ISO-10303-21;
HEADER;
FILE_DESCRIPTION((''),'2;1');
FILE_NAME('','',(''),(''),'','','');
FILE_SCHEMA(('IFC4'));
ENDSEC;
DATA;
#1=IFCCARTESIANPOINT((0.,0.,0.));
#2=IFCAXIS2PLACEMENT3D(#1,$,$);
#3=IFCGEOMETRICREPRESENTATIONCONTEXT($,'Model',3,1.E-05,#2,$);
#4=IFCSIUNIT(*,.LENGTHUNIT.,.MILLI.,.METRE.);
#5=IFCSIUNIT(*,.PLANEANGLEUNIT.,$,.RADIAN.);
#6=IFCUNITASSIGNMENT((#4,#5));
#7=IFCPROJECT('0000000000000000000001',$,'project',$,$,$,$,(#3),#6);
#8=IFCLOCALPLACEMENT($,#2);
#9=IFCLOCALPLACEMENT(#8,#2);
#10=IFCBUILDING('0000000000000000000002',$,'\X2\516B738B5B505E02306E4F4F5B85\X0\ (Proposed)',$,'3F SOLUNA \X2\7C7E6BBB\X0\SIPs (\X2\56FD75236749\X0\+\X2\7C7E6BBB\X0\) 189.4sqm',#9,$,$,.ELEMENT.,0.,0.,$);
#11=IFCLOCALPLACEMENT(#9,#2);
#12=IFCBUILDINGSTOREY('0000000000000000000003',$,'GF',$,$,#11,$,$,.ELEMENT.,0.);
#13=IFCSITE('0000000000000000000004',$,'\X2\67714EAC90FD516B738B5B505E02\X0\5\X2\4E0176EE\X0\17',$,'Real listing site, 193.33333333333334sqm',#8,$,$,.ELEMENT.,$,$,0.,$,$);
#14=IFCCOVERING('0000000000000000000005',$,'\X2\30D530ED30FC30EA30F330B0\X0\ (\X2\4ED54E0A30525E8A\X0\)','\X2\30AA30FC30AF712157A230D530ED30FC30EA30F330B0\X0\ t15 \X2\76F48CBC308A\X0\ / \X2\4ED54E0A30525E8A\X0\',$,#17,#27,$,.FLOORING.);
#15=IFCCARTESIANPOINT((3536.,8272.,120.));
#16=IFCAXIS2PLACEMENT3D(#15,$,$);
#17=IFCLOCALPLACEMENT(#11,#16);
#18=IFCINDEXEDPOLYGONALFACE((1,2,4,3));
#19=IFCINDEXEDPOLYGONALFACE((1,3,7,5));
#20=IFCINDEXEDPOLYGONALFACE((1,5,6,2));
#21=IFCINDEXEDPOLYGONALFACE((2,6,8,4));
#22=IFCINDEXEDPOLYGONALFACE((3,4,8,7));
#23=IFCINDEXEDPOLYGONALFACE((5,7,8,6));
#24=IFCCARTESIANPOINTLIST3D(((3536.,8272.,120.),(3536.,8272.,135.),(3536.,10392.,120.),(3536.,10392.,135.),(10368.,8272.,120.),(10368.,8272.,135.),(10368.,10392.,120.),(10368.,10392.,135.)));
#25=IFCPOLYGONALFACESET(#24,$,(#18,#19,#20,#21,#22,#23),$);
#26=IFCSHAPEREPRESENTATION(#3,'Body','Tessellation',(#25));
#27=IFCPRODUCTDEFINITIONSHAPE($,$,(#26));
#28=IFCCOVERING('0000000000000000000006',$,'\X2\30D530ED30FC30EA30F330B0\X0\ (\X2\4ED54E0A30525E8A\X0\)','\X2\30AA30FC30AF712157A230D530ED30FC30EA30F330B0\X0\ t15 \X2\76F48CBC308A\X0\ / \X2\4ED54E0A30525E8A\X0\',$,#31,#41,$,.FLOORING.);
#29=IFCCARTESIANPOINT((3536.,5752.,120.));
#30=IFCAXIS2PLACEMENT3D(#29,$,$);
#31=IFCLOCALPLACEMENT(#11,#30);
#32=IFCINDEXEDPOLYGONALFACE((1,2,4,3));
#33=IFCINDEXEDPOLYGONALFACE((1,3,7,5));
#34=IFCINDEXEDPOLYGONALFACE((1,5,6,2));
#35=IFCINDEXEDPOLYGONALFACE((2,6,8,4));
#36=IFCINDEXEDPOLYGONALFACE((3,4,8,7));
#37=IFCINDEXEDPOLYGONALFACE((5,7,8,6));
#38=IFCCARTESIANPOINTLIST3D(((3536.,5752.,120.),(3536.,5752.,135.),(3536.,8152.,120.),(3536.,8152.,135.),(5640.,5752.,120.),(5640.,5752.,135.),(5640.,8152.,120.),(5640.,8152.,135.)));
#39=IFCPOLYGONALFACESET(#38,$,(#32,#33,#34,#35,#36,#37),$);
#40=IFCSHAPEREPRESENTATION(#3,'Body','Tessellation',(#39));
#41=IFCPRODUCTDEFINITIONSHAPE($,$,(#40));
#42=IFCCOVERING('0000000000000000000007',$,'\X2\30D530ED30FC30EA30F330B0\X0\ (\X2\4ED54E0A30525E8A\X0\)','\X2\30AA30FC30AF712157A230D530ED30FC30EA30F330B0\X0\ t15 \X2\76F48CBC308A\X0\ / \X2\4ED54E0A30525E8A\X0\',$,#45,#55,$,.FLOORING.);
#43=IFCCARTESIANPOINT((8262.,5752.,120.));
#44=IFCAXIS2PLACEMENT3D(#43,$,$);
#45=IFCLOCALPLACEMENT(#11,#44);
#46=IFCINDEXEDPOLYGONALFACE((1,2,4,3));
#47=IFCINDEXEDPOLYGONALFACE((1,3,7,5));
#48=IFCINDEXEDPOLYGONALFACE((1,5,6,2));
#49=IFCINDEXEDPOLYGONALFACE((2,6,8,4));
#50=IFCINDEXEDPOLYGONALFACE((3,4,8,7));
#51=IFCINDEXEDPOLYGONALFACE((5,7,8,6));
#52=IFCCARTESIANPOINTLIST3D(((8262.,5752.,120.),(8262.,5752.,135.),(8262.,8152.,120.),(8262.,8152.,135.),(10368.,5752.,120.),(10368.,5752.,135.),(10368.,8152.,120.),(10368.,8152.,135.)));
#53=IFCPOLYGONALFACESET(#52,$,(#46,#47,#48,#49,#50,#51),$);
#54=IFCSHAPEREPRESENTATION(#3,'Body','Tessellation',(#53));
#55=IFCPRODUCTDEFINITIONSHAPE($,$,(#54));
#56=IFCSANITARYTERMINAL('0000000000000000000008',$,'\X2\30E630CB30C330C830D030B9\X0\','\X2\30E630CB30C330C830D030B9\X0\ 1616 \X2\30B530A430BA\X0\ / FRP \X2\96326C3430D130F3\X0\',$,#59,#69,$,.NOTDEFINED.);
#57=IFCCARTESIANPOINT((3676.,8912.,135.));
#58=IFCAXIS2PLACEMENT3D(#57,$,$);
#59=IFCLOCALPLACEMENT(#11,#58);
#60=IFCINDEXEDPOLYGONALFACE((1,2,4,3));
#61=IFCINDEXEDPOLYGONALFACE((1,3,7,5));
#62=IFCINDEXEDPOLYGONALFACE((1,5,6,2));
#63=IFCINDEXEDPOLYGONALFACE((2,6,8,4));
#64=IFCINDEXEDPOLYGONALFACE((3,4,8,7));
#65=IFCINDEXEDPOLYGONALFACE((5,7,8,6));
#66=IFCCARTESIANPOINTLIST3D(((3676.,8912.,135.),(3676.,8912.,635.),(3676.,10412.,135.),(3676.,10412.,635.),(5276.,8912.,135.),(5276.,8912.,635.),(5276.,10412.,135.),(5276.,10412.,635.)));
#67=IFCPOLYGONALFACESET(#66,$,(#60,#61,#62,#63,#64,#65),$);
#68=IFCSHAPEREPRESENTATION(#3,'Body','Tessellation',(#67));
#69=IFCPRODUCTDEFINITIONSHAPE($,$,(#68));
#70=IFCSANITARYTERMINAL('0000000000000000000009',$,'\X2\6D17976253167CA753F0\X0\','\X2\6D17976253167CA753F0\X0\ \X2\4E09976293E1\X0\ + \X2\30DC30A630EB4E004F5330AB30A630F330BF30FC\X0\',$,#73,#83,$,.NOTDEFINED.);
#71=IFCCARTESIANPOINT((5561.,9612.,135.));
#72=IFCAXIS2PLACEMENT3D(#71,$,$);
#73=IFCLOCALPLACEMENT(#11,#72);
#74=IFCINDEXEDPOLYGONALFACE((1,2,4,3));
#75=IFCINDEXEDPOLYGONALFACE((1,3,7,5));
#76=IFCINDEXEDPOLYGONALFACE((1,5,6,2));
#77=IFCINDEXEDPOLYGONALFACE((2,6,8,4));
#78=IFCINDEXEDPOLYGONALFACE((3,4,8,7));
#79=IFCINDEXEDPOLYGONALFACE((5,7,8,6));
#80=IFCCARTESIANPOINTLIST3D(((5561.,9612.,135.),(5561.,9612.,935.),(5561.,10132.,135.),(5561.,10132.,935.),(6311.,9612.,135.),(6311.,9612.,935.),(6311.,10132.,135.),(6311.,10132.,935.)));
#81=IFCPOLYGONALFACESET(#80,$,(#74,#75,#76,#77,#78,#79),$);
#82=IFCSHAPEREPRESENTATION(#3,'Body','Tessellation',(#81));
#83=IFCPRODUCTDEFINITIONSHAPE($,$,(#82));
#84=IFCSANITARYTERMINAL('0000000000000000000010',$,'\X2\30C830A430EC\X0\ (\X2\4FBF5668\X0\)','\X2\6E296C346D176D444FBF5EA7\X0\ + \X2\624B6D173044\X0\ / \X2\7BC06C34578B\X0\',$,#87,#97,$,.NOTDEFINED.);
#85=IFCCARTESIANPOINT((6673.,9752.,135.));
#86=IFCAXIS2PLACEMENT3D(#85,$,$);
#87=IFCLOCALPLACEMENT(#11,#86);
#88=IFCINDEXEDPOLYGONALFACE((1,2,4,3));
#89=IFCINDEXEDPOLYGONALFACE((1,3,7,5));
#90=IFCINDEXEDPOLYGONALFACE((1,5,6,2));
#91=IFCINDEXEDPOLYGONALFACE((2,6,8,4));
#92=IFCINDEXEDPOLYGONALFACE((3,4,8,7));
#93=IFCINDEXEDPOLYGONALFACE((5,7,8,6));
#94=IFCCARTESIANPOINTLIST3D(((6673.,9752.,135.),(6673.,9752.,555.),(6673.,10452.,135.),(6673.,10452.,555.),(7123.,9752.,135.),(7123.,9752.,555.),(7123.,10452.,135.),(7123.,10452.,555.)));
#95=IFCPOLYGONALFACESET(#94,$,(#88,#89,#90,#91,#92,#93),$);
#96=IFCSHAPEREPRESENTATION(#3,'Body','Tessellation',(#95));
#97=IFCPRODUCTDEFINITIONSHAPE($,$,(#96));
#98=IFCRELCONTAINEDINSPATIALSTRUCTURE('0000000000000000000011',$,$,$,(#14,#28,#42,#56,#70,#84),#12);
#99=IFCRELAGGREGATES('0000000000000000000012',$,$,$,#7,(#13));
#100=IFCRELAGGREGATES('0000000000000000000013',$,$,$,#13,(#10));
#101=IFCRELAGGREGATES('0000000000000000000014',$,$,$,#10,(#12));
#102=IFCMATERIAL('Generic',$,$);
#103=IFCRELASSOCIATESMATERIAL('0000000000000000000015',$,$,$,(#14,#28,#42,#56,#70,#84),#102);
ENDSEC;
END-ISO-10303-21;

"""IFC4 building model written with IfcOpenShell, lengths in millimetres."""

from ifc_helpers import new_model, si_unit, frame, frame_2d, origin, place, context, project, spatial, rectangle, extrude, material, element, save


model = new_model("IFC4")

# Units and contexts
model_context = context("Model", 3, precision=1e-05, world=origin())
ifc_project = project(units=[si_unit("LENGTHUNIT", "METRE", prefix="MILLI"), si_unit("PLANEANGLEUNIT", "RADIAN")], contexts=[model_context])

# Site, building, storey
site_placement = place(None, origin())
site = spatial("IfcSite", under=ifc_project, at=site_placement, Name="東京都八王子市5丁目17", ObjectType="Real listing site, 193.33333333333334sqm", CompositionType="ELEMENT", RefElevation=0.0)
building_placement = place(site_placement, origin())
building = spatial("IfcBuilding", under=site, at=building_placement, Name="八王子市の住宅 (Proposed)", ObjectType="3F SOLUNA 籾殻SIPs (国産杉+籾殻) 189.4sqm", CompositionType="ELEMENT", ElevationOfRefHeight=0.0, ElevationOfTerrain=0.0)
storey_placement = place(building_placement, origin())
storey = spatial("IfcBuildingStorey", under=building, at=storey_placement, Name="GF", CompositionType="ELEMENT", Elevation=0.0)

# Coverings
ifc_material_1 = material(Name="Generic")
covering_1_placement = place(storey_placement, frame((3536.0, 8272.0, 120.0)))
element("IfcCovering", 1, at=covering_1_placement, inside=storey, material=ifc_material_1, Name="フローリング (仕上げ床)", Description="オーク無垢フローリング t15 直貼り / 仕上げ床", PredefinedType="FLOORING", context=model_context, shape_type="SweptSolid", body=[
    extrude(rectangle(XDim=6832.0, YDim=2120.0, at=frame_2d((3416.0, 1060.0))), frame((3536.0, 8272.0, 120.0)), (0.0, 0.0, 1.0), 15.0),
])
covering_2_placement = place(storey_placement, frame((3536.0, 5752.0, 120.0)))
element("IfcCovering", 2, at=covering_2_placement, inside=storey, material=ifc_material_1, Name="フローリング (仕上げ床)", Description="オーク無垢フローリング t15 直貼り / 仕上げ床", PredefinedType="FLOORING", context=model_context, shape_type="SweptSolid", body=[
    extrude(rectangle(XDim=2104.0, YDim=2400.0, at=frame_2d((1052.0, 1200.0))), frame((3536.0, 5752.0, 120.0)), (0.0, 0.0, 1.0), 15.0),
])
covering_3_placement = place(storey_placement, frame((8262.0, 5752.0, 120.0)))
element("IfcCovering", 3, at=covering_3_placement, inside=storey, material=ifc_material_1, Name="フローリング (仕上げ床)", Description="オーク無垢フローリング t15 直貼り / 仕上げ床", PredefinedType="FLOORING", context=model_context, shape_type="SweptSolid", body=[
    extrude(rectangle(XDim=2106.0, YDim=2400.0, at=frame_2d((1053.0, 1200.0))), frame((8262.0, 5752.0, 120.0)), (0.0, 0.0, 1.0), 15.0),
])

# Sanitary terminals
sanitary_terminal_1_placement = place(storey_placement, frame((3676.0, 8912.0, 135.0)))
element("IfcSanitaryTerminal", 4, at=sanitary_terminal_1_placement, inside=storey, material=ifc_material_1, Name="ユニットバス", Description="ユニットバス 1616 サイズ / FRP 防水パン", PredefinedType="NOTDEFINED", context=model_context, shape_type="SweptSolid", body=[
    extrude(rectangle(XDim=1600.0, YDim=1500.0, at=frame_2d((800.0, 750.0))), frame((3676.0, 8912.0, 135.0)), (0.0, 0.0, 1.0), 500.0),
])
sanitary_terminal_2_placement = place(storey_placement, frame((5561.0, 9612.0, 135.0)))
element("IfcSanitaryTerminal", 5, at=sanitary_terminal_2_placement, inside=storey, material=ifc_material_1, Name="洗面化粧台", Description="洗面化粧台 三面鏡 + ボウル一体カウンター", PredefinedType="NOTDEFINED", context=model_context, shape_type="SweptSolid", body=[
    extrude(rectangle(XDim=750.0, YDim=520.0, at=frame_2d((375.0, 260.0))), frame((5561.0, 9612.0, 135.0)), (0.0, 0.0, 1.0), 800.0),
])
sanitary_terminal_3_placement = place(storey_placement, frame((6673.0, 9752.0, 135.0)))
element("IfcSanitaryTerminal", 6, at=sanitary_terminal_3_placement, inside=storey, material=ifc_material_1, Name="トイレ (便器)", Description="温水洗浄便座 + 手洗い / 節水型", PredefinedType="NOTDEFINED", context=model_context, shape_type="SweptSolid", body=[
    extrude(rectangle(XDim=450.0, YDim=700.0, at=frame_2d((225.0, 350.0))), frame((6673.0, 9752.0, 135.0)), (0.0, 0.0, 1.0), 420.0),
])

save(model, "model.ifc")
